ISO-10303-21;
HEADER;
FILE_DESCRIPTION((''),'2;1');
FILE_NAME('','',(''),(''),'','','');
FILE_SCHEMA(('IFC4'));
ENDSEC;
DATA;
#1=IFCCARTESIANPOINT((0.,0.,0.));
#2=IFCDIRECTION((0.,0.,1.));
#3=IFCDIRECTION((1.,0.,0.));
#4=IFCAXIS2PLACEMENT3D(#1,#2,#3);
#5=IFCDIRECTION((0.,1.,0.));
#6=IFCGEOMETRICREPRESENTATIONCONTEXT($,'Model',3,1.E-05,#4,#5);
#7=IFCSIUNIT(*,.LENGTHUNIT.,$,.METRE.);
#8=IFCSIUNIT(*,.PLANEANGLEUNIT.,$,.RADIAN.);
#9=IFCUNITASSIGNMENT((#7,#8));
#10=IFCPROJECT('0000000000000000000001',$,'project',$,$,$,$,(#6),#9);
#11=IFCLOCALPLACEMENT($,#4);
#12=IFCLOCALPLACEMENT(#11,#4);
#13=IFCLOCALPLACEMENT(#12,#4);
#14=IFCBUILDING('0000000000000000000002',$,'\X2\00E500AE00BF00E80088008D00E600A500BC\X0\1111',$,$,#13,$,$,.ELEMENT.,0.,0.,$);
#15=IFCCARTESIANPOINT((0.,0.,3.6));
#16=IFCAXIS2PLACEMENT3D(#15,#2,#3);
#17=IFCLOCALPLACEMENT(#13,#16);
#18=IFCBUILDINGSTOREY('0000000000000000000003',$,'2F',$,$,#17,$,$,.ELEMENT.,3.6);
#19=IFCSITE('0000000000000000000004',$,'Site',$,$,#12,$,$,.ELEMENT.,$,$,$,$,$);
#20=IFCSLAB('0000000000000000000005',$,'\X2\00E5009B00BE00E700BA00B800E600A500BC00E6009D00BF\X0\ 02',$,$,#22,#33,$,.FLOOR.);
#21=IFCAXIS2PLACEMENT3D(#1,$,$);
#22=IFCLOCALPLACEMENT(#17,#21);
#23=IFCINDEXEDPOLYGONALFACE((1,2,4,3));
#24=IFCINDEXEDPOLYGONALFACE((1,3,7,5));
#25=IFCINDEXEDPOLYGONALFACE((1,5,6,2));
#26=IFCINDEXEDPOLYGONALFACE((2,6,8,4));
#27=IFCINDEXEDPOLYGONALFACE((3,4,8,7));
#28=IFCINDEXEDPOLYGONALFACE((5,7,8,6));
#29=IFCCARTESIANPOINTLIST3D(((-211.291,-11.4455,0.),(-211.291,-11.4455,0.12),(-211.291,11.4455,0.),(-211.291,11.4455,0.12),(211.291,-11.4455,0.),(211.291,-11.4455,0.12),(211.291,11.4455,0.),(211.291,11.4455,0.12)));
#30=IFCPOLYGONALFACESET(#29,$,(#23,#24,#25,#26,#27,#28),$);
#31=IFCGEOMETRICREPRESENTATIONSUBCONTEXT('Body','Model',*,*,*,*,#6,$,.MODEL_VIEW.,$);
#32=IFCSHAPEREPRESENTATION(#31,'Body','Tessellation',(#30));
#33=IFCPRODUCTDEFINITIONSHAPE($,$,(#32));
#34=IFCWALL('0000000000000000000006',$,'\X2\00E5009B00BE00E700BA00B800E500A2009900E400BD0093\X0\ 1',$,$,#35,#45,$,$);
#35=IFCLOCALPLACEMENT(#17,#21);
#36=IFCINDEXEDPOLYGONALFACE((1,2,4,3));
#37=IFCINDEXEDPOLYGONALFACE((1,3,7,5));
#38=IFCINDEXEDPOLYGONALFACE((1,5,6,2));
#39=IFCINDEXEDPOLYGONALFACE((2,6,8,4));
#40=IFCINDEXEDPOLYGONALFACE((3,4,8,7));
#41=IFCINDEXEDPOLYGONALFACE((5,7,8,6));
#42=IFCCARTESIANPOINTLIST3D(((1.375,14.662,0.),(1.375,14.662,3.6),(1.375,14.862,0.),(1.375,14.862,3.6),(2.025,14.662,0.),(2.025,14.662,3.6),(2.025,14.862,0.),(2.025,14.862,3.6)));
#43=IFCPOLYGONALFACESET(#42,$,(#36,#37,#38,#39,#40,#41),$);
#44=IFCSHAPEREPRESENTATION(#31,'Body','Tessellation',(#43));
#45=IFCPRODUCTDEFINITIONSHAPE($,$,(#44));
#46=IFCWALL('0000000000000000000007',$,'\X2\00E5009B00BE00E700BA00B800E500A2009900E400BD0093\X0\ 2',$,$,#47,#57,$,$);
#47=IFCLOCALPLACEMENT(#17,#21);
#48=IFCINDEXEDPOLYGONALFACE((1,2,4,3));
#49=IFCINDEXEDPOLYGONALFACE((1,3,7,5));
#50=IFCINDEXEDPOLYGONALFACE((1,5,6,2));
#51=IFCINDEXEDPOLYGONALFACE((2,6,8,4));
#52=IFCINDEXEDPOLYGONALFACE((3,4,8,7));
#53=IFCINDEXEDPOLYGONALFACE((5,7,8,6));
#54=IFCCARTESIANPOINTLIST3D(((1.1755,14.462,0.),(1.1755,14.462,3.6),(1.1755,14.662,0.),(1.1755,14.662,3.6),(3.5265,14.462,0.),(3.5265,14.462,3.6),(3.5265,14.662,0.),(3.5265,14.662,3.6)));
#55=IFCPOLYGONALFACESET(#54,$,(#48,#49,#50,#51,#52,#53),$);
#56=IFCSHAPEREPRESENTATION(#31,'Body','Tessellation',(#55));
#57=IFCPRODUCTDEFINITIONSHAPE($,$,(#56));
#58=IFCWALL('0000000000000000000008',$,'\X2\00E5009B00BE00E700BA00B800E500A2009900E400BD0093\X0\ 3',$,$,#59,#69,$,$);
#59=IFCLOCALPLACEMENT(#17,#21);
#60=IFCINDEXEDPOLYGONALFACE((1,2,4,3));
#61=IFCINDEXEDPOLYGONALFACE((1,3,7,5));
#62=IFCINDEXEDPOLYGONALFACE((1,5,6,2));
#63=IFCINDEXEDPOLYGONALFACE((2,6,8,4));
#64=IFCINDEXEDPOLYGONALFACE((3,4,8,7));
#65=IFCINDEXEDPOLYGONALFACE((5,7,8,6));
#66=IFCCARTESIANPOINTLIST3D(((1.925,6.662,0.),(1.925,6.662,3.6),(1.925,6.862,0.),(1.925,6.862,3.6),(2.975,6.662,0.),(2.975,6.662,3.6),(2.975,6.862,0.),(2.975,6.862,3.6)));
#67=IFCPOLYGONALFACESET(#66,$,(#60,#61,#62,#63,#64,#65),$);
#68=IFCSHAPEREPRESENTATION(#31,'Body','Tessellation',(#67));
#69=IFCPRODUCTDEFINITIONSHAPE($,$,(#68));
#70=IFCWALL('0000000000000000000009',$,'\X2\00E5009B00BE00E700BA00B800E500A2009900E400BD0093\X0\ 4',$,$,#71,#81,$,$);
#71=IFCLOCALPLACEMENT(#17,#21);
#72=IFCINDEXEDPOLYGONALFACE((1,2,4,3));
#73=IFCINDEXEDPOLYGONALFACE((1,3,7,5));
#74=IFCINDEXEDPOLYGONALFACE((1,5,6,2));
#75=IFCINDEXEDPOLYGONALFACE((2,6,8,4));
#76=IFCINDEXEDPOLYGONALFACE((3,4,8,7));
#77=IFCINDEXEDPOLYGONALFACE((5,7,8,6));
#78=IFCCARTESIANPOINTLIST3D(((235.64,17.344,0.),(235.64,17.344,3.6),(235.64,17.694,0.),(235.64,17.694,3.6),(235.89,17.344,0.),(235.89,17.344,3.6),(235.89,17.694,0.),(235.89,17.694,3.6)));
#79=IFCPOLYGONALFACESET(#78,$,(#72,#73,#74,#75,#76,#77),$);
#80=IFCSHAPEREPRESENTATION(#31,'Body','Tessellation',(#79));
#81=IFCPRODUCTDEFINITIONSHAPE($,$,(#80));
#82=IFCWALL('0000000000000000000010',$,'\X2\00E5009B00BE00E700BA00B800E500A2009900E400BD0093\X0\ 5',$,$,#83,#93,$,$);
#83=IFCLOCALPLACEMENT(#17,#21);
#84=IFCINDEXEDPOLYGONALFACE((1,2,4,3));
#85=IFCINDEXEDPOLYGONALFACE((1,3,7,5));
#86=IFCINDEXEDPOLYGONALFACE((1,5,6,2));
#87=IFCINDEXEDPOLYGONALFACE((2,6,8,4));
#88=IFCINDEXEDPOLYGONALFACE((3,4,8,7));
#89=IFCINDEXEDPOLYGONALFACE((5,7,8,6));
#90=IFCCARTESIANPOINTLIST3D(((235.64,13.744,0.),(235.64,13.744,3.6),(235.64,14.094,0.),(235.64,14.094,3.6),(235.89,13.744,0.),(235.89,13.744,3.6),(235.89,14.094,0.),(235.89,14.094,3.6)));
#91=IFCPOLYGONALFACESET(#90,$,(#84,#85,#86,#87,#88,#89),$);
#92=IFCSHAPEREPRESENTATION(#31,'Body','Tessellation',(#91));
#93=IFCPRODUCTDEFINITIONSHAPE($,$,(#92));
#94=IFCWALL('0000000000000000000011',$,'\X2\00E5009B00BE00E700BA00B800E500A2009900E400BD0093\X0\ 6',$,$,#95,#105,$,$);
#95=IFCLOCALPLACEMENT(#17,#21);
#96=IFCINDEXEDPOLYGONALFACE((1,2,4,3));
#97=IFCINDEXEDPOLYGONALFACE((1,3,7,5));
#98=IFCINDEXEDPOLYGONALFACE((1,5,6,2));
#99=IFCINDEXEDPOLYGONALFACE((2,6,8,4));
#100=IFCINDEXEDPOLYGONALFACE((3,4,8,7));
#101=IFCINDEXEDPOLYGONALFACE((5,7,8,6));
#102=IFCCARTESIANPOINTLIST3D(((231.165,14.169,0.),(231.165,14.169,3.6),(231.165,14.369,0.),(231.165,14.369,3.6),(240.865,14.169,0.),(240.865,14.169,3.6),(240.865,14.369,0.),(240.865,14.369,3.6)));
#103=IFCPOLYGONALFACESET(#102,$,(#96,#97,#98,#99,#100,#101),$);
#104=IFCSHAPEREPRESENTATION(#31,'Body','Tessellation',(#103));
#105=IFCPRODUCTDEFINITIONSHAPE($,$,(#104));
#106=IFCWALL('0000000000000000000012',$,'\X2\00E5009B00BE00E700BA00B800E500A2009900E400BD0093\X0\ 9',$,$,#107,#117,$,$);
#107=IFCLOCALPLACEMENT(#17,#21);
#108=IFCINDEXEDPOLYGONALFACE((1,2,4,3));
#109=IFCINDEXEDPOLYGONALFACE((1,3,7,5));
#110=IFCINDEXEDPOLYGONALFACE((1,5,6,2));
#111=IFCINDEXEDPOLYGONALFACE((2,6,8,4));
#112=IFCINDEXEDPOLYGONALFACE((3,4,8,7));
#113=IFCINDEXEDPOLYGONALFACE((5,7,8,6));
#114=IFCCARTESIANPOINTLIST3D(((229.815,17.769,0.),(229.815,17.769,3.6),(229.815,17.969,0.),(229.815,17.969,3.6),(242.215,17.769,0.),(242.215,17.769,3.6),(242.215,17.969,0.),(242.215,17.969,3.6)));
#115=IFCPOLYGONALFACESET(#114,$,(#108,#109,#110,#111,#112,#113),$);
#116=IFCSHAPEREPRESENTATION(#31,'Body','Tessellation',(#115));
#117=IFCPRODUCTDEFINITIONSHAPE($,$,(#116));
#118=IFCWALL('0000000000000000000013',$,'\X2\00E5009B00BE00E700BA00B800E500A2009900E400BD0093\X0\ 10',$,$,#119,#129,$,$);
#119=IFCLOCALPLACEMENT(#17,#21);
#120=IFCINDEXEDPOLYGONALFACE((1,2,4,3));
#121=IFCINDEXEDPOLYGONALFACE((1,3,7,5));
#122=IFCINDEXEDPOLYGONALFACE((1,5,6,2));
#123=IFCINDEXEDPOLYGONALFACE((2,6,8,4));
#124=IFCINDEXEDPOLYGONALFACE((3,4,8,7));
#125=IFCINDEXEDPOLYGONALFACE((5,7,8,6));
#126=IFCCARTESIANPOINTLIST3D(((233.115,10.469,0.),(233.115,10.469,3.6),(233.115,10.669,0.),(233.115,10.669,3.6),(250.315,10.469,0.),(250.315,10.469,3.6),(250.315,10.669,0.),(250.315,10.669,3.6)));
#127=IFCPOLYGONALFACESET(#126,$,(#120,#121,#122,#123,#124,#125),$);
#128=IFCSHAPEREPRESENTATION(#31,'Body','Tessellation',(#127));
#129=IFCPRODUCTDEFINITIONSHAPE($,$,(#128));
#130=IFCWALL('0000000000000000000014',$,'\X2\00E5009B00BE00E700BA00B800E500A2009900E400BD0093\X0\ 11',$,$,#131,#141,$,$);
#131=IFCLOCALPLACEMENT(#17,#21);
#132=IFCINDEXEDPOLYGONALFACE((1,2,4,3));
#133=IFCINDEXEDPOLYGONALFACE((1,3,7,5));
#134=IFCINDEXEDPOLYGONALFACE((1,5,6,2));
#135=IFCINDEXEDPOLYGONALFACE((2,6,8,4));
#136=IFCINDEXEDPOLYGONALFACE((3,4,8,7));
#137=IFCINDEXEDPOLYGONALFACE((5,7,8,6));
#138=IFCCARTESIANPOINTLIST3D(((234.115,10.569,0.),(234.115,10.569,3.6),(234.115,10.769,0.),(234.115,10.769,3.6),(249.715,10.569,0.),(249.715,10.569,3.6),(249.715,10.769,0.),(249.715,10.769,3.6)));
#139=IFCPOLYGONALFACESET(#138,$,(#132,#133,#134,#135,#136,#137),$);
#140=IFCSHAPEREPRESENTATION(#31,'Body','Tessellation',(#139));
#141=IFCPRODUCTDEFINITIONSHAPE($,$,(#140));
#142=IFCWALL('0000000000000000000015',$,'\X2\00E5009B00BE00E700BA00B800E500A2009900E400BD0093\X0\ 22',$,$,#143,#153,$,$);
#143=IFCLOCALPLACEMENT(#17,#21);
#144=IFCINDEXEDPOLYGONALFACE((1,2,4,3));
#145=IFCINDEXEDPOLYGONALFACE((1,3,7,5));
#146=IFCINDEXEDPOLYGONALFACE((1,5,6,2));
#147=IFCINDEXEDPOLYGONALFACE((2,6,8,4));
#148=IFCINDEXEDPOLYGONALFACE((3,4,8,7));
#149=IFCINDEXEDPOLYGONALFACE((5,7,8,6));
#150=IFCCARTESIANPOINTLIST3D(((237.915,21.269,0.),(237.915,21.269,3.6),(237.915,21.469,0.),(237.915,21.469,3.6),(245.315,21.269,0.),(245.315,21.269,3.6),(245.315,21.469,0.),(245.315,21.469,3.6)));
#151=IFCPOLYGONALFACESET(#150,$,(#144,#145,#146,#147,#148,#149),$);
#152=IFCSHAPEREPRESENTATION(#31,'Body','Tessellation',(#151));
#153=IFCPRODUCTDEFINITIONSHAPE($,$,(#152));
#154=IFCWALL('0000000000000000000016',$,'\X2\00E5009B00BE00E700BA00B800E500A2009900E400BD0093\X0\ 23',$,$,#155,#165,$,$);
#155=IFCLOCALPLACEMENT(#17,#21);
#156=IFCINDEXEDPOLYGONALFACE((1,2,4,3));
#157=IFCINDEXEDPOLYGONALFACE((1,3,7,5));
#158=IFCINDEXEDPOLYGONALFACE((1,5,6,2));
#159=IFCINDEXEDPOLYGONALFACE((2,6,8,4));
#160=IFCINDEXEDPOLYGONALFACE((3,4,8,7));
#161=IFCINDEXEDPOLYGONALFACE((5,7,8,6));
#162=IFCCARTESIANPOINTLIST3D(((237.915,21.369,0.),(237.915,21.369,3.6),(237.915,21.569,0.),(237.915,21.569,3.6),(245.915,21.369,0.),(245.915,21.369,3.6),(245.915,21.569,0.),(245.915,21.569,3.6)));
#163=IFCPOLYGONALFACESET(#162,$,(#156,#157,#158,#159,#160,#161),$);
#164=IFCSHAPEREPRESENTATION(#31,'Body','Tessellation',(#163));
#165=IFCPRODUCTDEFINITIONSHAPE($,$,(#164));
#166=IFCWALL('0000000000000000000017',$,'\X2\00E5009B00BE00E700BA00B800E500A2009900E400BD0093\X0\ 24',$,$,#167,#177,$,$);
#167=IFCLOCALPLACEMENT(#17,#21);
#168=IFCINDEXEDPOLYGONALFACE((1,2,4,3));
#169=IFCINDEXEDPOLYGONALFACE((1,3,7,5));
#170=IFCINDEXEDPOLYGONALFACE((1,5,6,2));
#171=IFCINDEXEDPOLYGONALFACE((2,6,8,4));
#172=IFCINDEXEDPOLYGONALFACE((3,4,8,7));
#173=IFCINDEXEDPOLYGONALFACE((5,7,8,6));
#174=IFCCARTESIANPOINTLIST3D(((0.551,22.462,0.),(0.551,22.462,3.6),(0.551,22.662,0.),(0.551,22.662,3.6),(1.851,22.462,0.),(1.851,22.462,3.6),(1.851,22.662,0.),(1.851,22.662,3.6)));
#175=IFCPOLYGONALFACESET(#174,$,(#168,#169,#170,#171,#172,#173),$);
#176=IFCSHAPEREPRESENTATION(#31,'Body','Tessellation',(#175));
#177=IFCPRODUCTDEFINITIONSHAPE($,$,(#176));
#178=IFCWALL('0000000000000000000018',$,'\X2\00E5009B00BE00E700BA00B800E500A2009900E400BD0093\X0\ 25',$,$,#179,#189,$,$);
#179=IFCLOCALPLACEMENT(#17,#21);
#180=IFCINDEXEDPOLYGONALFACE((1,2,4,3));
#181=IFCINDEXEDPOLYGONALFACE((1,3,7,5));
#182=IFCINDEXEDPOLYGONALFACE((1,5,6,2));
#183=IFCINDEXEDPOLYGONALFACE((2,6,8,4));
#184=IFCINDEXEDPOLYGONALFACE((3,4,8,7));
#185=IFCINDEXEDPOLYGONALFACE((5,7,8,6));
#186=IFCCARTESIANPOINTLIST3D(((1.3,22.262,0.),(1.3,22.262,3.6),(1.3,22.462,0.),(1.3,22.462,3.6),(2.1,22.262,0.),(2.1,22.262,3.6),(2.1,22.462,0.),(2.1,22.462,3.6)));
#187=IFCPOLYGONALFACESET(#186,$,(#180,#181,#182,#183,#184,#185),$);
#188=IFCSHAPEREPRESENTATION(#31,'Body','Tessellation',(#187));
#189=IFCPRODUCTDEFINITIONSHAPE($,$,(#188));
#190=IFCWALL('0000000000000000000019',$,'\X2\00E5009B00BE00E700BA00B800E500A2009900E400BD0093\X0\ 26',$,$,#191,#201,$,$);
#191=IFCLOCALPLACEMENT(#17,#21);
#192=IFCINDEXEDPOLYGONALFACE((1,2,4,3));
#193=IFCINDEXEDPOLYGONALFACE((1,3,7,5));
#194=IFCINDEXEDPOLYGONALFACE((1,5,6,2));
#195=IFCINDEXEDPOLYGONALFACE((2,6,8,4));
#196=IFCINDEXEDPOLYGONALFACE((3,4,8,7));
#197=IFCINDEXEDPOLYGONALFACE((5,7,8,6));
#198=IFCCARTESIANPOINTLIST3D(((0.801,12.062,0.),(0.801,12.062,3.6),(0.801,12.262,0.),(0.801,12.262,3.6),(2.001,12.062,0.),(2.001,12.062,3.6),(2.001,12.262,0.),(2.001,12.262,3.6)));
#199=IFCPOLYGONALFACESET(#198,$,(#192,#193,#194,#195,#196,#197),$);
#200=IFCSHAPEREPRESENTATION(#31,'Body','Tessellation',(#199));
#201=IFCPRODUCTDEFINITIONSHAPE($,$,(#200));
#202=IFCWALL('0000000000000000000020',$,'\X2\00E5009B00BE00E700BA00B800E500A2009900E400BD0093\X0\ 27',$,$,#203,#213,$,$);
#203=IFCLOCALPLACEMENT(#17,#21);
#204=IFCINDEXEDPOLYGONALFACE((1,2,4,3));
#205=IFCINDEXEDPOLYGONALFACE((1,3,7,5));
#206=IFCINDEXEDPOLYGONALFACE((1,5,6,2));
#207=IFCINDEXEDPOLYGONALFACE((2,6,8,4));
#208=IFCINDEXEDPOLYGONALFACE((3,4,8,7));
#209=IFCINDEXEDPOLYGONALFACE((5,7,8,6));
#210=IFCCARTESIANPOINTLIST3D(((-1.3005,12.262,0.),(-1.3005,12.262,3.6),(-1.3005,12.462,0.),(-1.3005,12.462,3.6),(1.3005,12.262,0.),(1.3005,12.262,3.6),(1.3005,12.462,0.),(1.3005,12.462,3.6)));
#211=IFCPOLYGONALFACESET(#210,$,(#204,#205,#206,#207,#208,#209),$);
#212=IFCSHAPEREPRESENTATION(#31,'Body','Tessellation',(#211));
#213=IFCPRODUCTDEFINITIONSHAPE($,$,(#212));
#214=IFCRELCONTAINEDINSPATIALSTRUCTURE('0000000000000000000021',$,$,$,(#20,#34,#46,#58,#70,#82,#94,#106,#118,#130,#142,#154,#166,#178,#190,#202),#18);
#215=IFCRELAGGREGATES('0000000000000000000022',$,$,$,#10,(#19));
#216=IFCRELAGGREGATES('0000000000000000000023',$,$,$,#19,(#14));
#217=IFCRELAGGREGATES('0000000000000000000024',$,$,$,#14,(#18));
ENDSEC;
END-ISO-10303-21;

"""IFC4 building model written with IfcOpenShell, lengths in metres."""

from ifc_helpers import new_model, si_unit, direction, frame, frame_2d, origin_with_axes, place, context, subcontext, project, spatial, rectangle, extrude, element, save


model = new_model("IFC4")

# Units and contexts
model_context = context("Model", 3, precision=1e-05, world=origin_with_axes(), true_north=direction((0.0, 1.0, 0.0)))
body_context = subcontext(model_context, "Body", "Model", "MODEL_VIEW")
ifc_project = project(units=[si_unit("LENGTHUNIT", "METRE"), si_unit("PLANEANGLEUNIT", "RADIAN")], contexts=[model_context])

# Site, building, storey
placement = place(None, origin_with_axes())
site_placement = place(placement, origin_with_axes())
site = spatial("IfcSite", under=ifc_project, at=site_placement, Name="Site", CompositionType="ELEMENT")
building_placement = place(site_placement, origin_with_axes())
building = spatial("IfcBuilding", under=site, at=building_placement, Name="å®¿è\u0088\u008dæ¥¼1111", CompositionType="ELEMENT", ElevationOfRefHeight=0.0, ElevationOfTerrain=0.0)
storey_placement = place(building_placement, frame((0.0, 0.0, 3.6), z_axis=(0.0, 0.0, 1.0), x_axis=(1.0, 0.0, 0.0)))
storey = spatial("IfcBuildingStorey", under=building, at=storey_placement, Name="2F", CompositionType="ELEMENT", Elevation=3.6)

# Slab
slab_placement = place(storey_placement, origin_with_axes())
element("IfcSlab", 1, at=slab_placement, inside=storey, Name="å\u009b¾çº¸æ¥¼æ\u009d¿ 02", PredefinedType="FLOOR", context=body_context, shape_type="SweptSolid", body=[
    extrude(rectangle(XDim=422.582, YDim=22.891, at=frame_2d((0.0, 0.0), x_axis=(1.0, 0.0, 0.0))), frame((0.0, 0.0, 0.0), z_axis=(0.0, 0.0, 1.0)), (0.0, 0.0, 1.0), 0.12),
])

# Walls
wall_1_placement = place(storey_placement, frame((1.7, 14.762, 0.0), z_axis=(0.0, 0.0, 1.0), x_axis=(1.0, 0.0, 0.0)))
element("IfcWall", 2, at=wall_1_placement, inside=storey, Name="å\u009b¾çº¸å¢\u0099ä½\u0093 1", context=body_context, shape_type="SweptSolid", body=[
    extrude(rectangle(XDim=0.65, YDim=0.2, at=frame_2d((0.0, 0.0), x_axis=(1.0, 0.0, 0.0))), frame((0.0, 0.0, 0.0), z_axis=(0.0, 0.0, 1.0)), (0.0, 0.0, 1.0), 3.6),
])
wall_2_placement = place(storey_placement, frame((2.351, 14.562, 0.0), z_axis=(0.0, 0.0, 1.0), x_axis=(-1.0, 0.0, 0.0)))
element("IfcWall", 3, at=wall_2_placement, inside=storey, Name="å\u009b¾çº¸å¢\u0099ä½\u0093 2", context=body_context, shape_type="SweptSolid", body=[
    extrude(rectangle(XDim=2.351, YDim=0.2, at=frame_2d((0.0, 0.0), x_axis=(1.0, 0.0, 0.0))), frame((0.0, 0.0, 0.0), z_axis=(0.0, 0.0, 1.0)), (0.0, 0.0, 1.0), 3.6),
])
wall_3_placement = place(storey_placement, frame((2.45, 6.762, 0.0), z_axis=(0.0, 0.0, 1.0), x_axis=(-1.0, 0.0, 0.0)))
element("IfcWall", 4, at=wall_3_placement, inside=storey, Name="å\u009b¾çº¸å¢\u0099ä½\u0093 3", context=body_context, shape_type="SweptSolid", body=[
    extrude(rectangle(XDim=1.05, YDim=0.2, at=frame_2d((0.0, 0.0), x_axis=(1.0, 0.0, 0.0))), frame((0.0, 0.0, 0.0), z_axis=(0.0, 0.0, 1.0)), (0.0, 0.0, 1.0), 3.6),
])
for number, where, z_axis, x_axis, name in (
    (5, (235.765, 17.519, 0.0), (0.0, 0.0, 1.0), (1.0, 0.0, 0.0), "å\u009b¾çº¸å¢\u0099ä½\u0093 4"),
    (6, (235.765, 13.919, 0.0), (0.0, 0.0, 1.0), (1.0, 0.0, 0.0), "å\u009b¾çº¸å¢\u0099ä½\u0093 5"),
):
    element("IfcWall", number, at=place(storey_placement, frame(where, z_axis=z_axis, x_axis=x_axis)), inside=storey, Name=name, context=body_context, shape_type="SweptSolid", body=[
        extrude(rectangle(XDim=0.25, YDim=0.35, at=frame_2d((0.0, 0.0), x_axis=(1.0, 0.0, 0.0))), frame((0.0, 0.0, 0.0), z_axis=(0.0, 0.0, 1.0)), (0.0, 0.0, 1.0), 3.6),
    ])
wall_4_placement = place(storey_placement, frame((236.015, 14.269, 0.0), z_axis=(0.0, 0.0, 1.0), x_axis=(-1.0, 0.0, 0.0)))
element("IfcWall", 7, at=wall_4_placement, inside=storey, Name="å\u009b¾çº¸å¢\u0099ä½\u0093 6", context=body_context, shape_type="SweptSolid", body=[
    extrude(rectangle(XDim=9.7, YDim=0.2, at=frame_2d((0.0, 0.0), x_axis=(1.0, 0.0, 0.0))), frame((0.0, 0.0, 0.0), z_axis=(0.0, 0.0, 1.0)), (0.0, 0.0, 1.0), 3.6),
])
wall_5_placement = place(storey_placement, frame((236.015, 17.869, 0.0), z_axis=(0.0, 0.0, 1.0), x_axis=(-1.0, 0.0, 0.0)))
element("IfcWall", 8, at=wall_5_placement, inside=storey, Name="å\u009b¾çº¸å¢\u0099ä½\u0093 9", context=body_context, shape_type="SweptSolid", body=[
    extrude(rectangle(XDim=12.4, YDim=0.2, at=frame_2d((0.0, 0.0), x_axis=(1.0, 0.0, 0.0))), frame((0.0, 0.0, 0.0), z_axis=(0.0, 0.0, 1.0)), (0.0, 0.0, 1.0), 3.6),
])
wall_6_placement = place(storey_placement, frame((241.715, 10.569, 0.0), z_axis=(0.0, 0.0, 1.0), x_axis=(-1.0, 0.0, 0.0)))
element("IfcWall", 9, at=wall_6_placement, inside=storey, Name="å\u009b¾çº¸å¢\u0099ä½\u0093 10", context=body_context, shape_type="SweptSolid", body=[
    extrude(rectangle(XDim=17.2, YDim=0.2, at=frame_2d((0.0, 0.0), x_axis=(1.0, 0.0, 0.0))), frame((0.0, 0.0, 0.0), z_axis=(0.0, 0.0, 1.0)), (0.0, 0.0, 1.0), 3.6),
])
wall_7_placement = place(storey_placement, frame((241.915, 10.669, 0.0), z_axis=(0.0, 0.0, 1.0), x_axis=(-1.0, 0.0, 0.0)))
element("IfcWall", 10, at=wall_7_placement, inside=storey, Name="å\u009b¾çº¸å¢\u0099ä½\u0093 11", context=body_context, shape_type="SweptSolid", body=[
    extrude(rectangle(XDim=15.6, YDim=0.2, at=frame_2d((0.0, 0.0), x_axis=(1.0, 0.0, 0.0))), frame((0.0, 0.0, 0.0), z_axis=(0.0, 0.0, 1.0)), (0.0, 0.0, 1.0), 3.6),
])
wall_8_placement = place(storey_placement, frame((241.615, 21.369, 0.0), z_axis=(0.0, 0.0, 1.0), x_axis=(-1.0, 0.0, 0.0)))
element("IfcWall", 11, at=wall_8_placement, inside=storey, Name="å\u009b¾çº¸å¢\u0099ä½\u0093 22", context=body_context, shape_type="SweptSolid", body=[
    extrude(rectangle(XDim=7.4, YDim=0.2, at=frame_2d((0.0, 0.0), x_axis=(1.0, 0.0, 0.0))), frame((0.0, 0.0, 0.0), z_axis=(0.0, 0.0, 1.0)), (0.0, 0.0, 1.0), 3.6),
])
wall_9_placement = place(storey_placement, frame((241.915, 21.469, 0.0), z_axis=(0.0, 0.0, 1.0), x_axis=(-1.0, 0.0, 0.0)))
element("IfcWall", 12, at=wall_9_placement, inside=storey, Name="å\u009b¾çº¸å¢\u0099ä½\u0093 23", context=body_context, shape_type="SweptSolid", body=[
    extrude(rectangle(XDim=8.0, YDim=0.2, at=frame_2d((0.0, 0.0), x_axis=(1.0, 0.0, 0.0))), frame((0.0, 0.0, 0.0), z_axis=(0.0, 0.0, 1.0)), (0.0, 0.0, 1.0), 3.6),
])
wall_10_placement = place(storey_placement, frame((1.201, 22.562, 0.0), z_axis=(0.0, 0.0, 1.0), x_axis=(1.0, 0.0, 0.0)))
element("IfcWall", 13, at=wall_10_placement, inside=storey, Name="å\u009b¾çº¸å¢\u0099ä½\u0093 24", context=body_context, shape_type="SweptSolid", body=[
    extrude(rectangle(XDim=1.3, YDim=0.2, at=frame_2d((0.0, 0.0), x_axis=(1.0, 0.0, 0.0))), frame((0.0, 0.0, 0.0), z_axis=(0.0, 0.0, 1.0)), (0.0, 0.0, 1.0), 3.6),
])
wall_11_placement = place(storey_placement, frame((1.7, 22.362, 0.0), z_axis=(0.0, 0.0, 1.0), x_axis=(1.0, 0.0, 0.0)))
element("IfcWall", 14, at=wall_11_placement, inside=storey, Name="å\u009b¾çº¸å¢\u0099ä½\u0093 25", context=body_context, shape_type="SweptSolid", body=[
    extrude(rectangle(XDim=0.8, YDim=0.2, at=frame_2d((0.0, 0.0), x_axis=(1.0, 0.0, 0.0))), frame((0.0, 0.0, 0.0), z_axis=(0.0, 0.0, 1.0)), (0.0, 0.0, 1.0), 3.6),
])
wall_12_placement = place(storey_placement, frame((1.401, 12.162, 0.0), z_axis=(0.0, 0.0, 1.0), x_axis=(1.0, 0.0, 0.0)))
element("IfcWall", 15, at=wall_12_placement, inside=storey, Name="å\u009b¾çº¸å¢\u0099ä½\u0093 26", context=body_context, shape_type="SweptSolid", body=[
    extrude(rectangle(XDim=1.2, YDim=0.2, at=frame_2d((0.0, 0.0), x_axis=(1.0, 0.0, 0.0))), frame((0.0, 0.0, 0.0), z_axis=(0.0, 0.0, 1.0)), (0.0, 0.0, 1.0), 3.6),
])
wall_13_placement = place(storey_placement, frame((0.0, 12.362, 0.0), z_axis=(0.0, 0.0, 1.0), x_axis=(1.0, 0.0, 0.0)))
element("IfcWall", 16, at=wall_13_placement, inside=storey, Name="å\u009b¾çº¸å¢\u0099ä½\u0093 27", context=body_context, shape_type="SweptSolid", body=[
    extrude(rectangle(XDim=2.601, YDim=0.2, at=frame_2d((0.0, 0.0), x_axis=(1.0, 0.0, 0.0))), frame((0.0, 0.0, 0.0), z_axis=(0.0, 0.0, 1.0)), (0.0, 0.0, 1.0), 3.6),
])

save(model, "model.ifc")
